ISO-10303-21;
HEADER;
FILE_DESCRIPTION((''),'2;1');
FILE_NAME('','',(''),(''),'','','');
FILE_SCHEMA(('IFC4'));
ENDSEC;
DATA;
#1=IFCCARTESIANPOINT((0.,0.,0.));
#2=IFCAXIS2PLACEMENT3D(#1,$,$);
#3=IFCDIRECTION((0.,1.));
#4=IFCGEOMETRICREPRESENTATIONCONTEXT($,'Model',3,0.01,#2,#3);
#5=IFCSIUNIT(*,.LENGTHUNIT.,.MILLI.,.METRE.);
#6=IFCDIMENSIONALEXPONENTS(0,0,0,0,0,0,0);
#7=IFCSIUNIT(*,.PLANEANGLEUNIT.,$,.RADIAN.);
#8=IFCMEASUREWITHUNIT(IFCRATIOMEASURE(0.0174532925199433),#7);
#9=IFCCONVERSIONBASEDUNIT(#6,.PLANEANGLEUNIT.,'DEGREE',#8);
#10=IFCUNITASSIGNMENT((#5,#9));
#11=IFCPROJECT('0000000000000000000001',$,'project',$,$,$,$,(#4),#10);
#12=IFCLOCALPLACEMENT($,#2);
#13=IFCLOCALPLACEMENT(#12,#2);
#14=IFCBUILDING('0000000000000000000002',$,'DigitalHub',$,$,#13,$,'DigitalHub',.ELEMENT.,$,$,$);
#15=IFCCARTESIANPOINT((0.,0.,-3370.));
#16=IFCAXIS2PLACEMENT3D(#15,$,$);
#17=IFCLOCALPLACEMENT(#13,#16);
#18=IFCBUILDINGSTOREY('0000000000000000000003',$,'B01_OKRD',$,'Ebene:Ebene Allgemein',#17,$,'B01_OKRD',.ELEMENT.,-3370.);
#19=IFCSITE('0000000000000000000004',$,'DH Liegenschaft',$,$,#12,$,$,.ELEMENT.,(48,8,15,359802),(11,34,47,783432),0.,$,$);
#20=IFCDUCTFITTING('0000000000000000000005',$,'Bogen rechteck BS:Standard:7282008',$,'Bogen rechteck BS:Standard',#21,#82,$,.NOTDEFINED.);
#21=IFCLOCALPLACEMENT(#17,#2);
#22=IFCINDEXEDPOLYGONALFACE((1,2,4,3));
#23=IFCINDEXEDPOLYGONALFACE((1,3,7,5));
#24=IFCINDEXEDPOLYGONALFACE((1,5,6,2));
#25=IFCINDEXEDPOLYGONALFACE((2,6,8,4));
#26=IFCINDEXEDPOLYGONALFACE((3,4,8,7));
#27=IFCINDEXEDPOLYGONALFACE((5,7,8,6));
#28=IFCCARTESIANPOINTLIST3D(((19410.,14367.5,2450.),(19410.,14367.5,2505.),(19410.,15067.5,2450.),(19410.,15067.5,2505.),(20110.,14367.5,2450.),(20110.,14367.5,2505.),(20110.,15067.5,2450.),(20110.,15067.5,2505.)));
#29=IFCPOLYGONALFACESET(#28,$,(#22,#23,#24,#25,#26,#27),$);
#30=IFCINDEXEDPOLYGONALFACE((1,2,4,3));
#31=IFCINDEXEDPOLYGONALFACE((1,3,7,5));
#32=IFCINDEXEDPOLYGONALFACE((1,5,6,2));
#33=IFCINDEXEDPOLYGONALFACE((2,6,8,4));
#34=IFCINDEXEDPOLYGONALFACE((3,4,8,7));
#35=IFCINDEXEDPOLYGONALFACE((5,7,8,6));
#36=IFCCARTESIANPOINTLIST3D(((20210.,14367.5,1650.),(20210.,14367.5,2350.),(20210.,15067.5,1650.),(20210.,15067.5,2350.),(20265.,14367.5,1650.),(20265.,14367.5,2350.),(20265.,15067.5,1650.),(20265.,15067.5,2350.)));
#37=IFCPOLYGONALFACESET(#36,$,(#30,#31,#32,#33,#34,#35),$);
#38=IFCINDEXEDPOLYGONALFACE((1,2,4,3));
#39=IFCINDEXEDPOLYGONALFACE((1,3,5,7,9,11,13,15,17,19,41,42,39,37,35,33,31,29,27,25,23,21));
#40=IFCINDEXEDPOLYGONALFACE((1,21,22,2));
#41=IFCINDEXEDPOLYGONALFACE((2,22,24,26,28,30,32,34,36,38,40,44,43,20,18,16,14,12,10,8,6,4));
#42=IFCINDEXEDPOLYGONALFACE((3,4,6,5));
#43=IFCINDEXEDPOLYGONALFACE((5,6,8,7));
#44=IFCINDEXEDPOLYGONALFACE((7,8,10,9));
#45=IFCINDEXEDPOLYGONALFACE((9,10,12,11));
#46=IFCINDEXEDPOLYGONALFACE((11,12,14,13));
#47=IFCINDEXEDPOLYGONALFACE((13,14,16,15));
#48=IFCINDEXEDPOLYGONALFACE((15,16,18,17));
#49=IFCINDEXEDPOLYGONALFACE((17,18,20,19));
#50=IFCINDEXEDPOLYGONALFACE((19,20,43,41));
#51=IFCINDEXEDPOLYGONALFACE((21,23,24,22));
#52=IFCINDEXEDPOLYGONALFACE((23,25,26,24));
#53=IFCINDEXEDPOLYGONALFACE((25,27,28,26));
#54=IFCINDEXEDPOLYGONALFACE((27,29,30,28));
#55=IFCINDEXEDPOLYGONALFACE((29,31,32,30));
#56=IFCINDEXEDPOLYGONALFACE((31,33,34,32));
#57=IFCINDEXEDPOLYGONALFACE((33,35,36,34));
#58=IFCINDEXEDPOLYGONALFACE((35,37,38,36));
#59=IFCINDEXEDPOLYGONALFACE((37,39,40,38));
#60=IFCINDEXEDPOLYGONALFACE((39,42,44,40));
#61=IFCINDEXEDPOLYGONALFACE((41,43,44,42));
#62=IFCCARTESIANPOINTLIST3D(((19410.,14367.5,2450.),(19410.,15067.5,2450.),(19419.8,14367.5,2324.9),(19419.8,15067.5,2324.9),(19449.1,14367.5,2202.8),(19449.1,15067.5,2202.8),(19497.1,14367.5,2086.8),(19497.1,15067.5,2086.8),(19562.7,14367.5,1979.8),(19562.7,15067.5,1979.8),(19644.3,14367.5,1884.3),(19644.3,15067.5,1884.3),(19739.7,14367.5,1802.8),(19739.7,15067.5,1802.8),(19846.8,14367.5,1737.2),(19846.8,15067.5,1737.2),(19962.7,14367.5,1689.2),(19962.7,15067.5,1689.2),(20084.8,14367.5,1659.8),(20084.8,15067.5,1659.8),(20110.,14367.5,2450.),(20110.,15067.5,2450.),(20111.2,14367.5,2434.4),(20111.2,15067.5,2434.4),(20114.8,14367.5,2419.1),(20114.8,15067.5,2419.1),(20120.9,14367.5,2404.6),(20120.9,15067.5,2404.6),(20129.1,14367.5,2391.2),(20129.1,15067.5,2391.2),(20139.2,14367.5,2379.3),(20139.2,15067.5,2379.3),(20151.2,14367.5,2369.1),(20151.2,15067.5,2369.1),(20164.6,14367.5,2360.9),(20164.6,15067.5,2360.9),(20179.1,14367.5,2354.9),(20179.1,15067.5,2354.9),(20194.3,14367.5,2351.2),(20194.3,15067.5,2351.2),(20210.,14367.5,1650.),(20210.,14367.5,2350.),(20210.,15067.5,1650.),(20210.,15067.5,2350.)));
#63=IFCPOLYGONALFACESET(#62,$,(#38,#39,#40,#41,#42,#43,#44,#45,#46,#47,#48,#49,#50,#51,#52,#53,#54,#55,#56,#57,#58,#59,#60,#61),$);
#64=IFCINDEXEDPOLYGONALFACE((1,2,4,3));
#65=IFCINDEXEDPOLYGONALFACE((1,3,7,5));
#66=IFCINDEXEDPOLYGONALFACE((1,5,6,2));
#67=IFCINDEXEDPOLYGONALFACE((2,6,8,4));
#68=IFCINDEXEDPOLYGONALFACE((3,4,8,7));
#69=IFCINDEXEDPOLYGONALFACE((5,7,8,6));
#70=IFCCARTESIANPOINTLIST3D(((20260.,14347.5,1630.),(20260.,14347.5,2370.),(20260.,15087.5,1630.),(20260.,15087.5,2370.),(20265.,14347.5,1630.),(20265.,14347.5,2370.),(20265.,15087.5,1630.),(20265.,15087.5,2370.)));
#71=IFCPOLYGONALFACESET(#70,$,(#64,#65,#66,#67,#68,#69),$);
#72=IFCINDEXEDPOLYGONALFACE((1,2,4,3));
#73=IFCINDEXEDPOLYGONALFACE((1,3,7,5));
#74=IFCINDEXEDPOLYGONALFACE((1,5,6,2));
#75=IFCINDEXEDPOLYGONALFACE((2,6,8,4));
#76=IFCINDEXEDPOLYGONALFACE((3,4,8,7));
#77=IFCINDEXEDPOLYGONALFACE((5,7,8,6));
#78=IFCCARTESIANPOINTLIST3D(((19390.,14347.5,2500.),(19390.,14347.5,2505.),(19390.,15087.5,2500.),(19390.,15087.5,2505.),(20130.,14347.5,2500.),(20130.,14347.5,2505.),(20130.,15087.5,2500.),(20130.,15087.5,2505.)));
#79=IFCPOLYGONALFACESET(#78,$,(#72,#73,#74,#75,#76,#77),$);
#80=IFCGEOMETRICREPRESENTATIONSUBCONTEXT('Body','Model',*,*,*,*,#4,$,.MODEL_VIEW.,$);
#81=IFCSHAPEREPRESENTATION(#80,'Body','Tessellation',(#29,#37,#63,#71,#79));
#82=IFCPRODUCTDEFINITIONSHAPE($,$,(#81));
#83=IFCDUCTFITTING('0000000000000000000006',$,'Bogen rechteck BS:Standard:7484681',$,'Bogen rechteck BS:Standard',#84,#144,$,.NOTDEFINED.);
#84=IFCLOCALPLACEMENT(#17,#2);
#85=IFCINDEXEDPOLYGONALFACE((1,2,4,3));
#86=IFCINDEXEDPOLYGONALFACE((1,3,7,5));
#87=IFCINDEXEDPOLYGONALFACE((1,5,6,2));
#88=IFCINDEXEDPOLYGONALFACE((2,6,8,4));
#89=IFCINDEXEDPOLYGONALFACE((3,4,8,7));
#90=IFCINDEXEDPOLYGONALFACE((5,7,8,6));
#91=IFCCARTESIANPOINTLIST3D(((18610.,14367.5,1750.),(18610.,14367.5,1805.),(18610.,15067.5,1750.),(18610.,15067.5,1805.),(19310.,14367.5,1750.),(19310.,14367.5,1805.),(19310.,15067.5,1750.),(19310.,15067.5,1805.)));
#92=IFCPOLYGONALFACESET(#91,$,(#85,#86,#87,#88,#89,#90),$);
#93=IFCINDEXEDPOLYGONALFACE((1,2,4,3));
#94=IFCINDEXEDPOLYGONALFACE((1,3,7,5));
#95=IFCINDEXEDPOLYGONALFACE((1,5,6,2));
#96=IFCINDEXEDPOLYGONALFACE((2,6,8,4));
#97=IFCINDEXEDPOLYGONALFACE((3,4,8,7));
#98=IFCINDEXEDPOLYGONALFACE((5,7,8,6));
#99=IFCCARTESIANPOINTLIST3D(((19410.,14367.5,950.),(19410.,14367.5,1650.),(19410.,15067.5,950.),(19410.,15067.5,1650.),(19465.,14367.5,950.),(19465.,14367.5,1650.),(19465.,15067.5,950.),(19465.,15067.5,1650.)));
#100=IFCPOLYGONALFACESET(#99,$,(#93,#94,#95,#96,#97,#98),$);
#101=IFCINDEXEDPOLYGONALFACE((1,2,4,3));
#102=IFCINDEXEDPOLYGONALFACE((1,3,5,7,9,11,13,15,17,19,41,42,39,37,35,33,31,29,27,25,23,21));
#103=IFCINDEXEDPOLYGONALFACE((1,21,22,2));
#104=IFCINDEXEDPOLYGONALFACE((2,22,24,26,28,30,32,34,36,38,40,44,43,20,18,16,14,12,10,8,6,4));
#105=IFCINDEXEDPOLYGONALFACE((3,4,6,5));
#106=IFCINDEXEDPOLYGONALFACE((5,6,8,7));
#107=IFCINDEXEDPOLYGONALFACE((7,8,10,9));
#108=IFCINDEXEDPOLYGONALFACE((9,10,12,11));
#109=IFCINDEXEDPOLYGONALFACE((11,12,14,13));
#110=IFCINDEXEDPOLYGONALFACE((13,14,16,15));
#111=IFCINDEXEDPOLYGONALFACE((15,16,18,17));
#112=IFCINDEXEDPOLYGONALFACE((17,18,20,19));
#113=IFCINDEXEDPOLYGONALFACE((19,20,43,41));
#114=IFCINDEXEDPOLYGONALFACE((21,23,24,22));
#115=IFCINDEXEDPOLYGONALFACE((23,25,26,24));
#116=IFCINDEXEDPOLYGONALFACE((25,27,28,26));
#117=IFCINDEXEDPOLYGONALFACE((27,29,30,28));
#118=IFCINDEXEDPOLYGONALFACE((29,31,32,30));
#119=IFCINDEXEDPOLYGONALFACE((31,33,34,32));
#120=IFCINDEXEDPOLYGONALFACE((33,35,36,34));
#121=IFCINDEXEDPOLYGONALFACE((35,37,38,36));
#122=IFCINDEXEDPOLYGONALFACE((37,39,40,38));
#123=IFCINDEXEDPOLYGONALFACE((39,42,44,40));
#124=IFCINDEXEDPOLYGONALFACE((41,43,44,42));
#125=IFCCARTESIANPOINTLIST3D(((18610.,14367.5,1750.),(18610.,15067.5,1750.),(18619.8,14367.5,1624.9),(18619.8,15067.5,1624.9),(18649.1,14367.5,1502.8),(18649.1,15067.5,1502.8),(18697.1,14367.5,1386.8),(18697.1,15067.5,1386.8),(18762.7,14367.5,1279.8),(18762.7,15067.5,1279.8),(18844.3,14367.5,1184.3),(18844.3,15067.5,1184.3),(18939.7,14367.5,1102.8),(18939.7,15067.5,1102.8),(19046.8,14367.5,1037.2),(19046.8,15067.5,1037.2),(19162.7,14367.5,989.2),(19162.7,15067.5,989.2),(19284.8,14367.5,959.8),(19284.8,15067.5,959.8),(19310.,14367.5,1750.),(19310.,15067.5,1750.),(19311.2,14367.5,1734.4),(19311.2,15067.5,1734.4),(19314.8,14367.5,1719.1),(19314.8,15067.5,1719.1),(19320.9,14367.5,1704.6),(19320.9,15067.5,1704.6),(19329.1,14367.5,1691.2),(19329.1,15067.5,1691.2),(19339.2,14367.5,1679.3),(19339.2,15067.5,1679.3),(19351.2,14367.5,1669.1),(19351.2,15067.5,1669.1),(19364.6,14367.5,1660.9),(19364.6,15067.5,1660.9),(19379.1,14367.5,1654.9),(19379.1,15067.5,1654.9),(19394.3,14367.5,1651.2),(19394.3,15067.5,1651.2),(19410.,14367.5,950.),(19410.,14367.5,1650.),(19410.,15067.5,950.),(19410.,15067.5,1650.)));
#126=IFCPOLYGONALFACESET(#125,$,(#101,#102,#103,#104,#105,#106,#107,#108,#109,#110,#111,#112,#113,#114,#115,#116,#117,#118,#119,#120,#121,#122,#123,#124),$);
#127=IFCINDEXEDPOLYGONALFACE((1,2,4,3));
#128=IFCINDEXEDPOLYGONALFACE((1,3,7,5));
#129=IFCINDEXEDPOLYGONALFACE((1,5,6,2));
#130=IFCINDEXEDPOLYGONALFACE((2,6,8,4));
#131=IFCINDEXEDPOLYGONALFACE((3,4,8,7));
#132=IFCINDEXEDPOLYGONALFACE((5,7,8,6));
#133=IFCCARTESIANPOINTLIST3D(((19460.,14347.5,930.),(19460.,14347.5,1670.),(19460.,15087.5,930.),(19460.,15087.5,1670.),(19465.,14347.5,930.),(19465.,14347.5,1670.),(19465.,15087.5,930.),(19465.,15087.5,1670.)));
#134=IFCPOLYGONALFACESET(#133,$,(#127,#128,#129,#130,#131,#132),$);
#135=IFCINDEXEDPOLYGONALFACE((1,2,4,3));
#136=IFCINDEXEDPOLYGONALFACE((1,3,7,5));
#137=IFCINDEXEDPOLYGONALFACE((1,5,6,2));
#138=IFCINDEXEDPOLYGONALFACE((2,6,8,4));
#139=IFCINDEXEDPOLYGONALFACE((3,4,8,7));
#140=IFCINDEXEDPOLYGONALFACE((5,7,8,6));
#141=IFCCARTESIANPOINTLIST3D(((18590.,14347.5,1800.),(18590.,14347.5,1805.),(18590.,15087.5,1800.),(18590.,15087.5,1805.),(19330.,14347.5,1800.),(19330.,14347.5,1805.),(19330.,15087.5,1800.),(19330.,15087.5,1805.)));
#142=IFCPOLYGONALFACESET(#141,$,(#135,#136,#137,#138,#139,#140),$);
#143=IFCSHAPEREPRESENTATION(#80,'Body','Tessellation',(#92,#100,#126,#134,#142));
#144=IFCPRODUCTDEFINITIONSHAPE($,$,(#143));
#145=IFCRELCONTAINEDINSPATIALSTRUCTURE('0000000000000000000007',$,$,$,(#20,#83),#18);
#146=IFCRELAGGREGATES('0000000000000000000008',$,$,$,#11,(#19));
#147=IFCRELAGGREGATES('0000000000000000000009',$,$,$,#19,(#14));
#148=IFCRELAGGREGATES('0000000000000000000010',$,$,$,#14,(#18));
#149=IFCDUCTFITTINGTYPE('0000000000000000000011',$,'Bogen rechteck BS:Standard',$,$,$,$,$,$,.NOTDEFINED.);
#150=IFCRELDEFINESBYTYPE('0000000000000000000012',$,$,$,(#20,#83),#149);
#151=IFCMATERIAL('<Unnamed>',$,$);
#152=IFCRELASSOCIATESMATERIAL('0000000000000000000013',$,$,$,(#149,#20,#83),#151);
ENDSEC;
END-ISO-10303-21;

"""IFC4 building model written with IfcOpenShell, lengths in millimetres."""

from ifc_helpers import new_model, entity, si_unit, converted_unit, direction, frame, origin, place, context, subcontext, project, spatial, indexed_curve, outline, extrude, source, transform, mapped, material, type_object, type_shapes, element, save


model = new_model("IFC4")

# Units and contexts
model_context = context("Model", 3, precision=0.01, world=origin(), true_north=direction((0.0, 1.0)))
body_context = subcontext(model_context, "Body", "Model", "MODEL_VIEW")
ifc_project = project(units=[si_unit("LENGTHUNIT", "METRE", prefix="MILLI"), converted_unit("PLANEANGLEUNIT", "DEGREE", entity("IfcRatioMeasure", 0.0174532925199433), si_unit("PLANEANGLEUNIT", "RADIAN"), dimensions=[0, 0, 0, 0, 0, 0, 0])], contexts=[model_context])

# Site, building, storey
site_placement = place(None, origin())
site = spatial("IfcSite", under=ifc_project, at=site_placement, Name="DH Liegenschaft", CompositionType="ELEMENT", RefLatitude=(48, 8, 15, 359802), RefLongitude=(11, 34, 47, 783432), RefElevation=0.0)
building_placement = place(site_placement, origin())
building = spatial("IfcBuilding", under=site, at=building_placement, Name="DigitalHub", LongName="DigitalHub", CompositionType="ELEMENT")
storey_placement = place(building_placement, frame((0.0, 0.0, -3370.0)))
storey = spatial("IfcBuildingStorey", under=building, at=storey_placement, Name="B01_OKRD", ObjectType="Ebene:Ebene Allgemein", LongName="B01_OKRD", CompositionType="ELEMENT", Elevation=-3370.0)

# Shared definitions
ifc_material_1 = material(Name="<Unnamed>")

# Duct fittings
duct_fitting_type_1 = type_object("IfcDuctFittingType", Name="Bogen rechteck BS:Standard", PredefinedType="NOTDEFINED", material=ifc_material_1)
shared_shape_1 = source(origin(), body_context, "Body", "SweptSolid", [
    extrude(outline(indexed_curve([(-27.5, -350.0), (27.5, -350.0), (27.5, 350.0), (-27.5, 350.0), (-27.5, -350.0)], self_intersect=False)), frame((0.0, 477.5, -350.0), z_axis=(0.0, 0.0, 1.0), x_axis=(0.0, 1.0, 0.0)), (0.0, 0.0, 1.0), 700.0),
    extrude(outline(indexed_curve([(-350.0, -27.5), (350.0, -27.5), (350.0, 27.5), (-350.0, 27.5), (-350.0, -27.5)], self_intersect=False)), frame((-477.5, 0.0, -350.0), z_axis=(0.0, 0.0, 1.0), x_axis=(0.0, -1.0, 0.0)), (0.0, 0.0, 1.0), 700.0),
    extrude(outline(indexed_curve([(-575.0, -225.0), (125.0, -225.0), (126.2, -209.4), (129.9, -194.1), (135.9, -179.6), (144.1, -166.2), (154.3, -154.3), (166.2, -144.1), (179.6, -135.9), (194.1, -129.9), (209.4, -126.2), (225.0, -125.0), (225.0, 575.0), (99.9, 565.2), (-22.2, 535.8), (-138.2, 487.8), (-245.2, 422.2), (-340.7, 340.7), (-422.2, 245.2), (-487.8, 138.2), (-535.8, 22.2), (-565.2, -99.9), (-575.0, -225.0)], self_intersect=False)), frame((-225.0, 225.0, -350.0), z_axis=(0.0, 0.0, 1.0), x_axis=(-1.0, 0.0, 0.0)), (0.0, 0.0, 1.0), 700.0),
    extrude(outline(indexed_curve([(-2.5, -370.0), (2.5, -370.0), (2.5, 370.0), (-2.5, 370.0), (-2.5, -370.0)], self_intersect=False)), frame((-502.5, 0.0, -370.0)), (0.0, 0.0, 1.0), 740.0),
    extrude(outline(indexed_curve([(-2.5, -370.0), (2.5, -370.0), (2.5, 370.0), (-2.5, 370.0), (-2.5, -370.0)], self_intersect=False)), frame((0.0, 502.5, -370.0), z_axis=(0.0, 0.0, 1.0), x_axis=(0.0, 1.0, 0.0)), (0.0, 0.0, 1.0), 740.0),
])
type_shapes(duct_fitting_type_1, [shared_shape_1])
for number, where, z_axis, x_axis, name in (
    (1, (19760.0, 14717.5, 2000.0), (0.0, 1.0, 0.0), (-1.0, 0.0, 0.0), "Bogen rechteck BS:Standard:7282008"),
    (2, (18960.0, 14717.5, 1300.0), (0.0, 1.0, 0.0), (-1.0, 0.0, 0.0), "Bogen rechteck BS:Standard:7484681"),
):
    element("IfcDuctFitting", number, at=place(storey_placement, frame(where, z_axis=z_axis, x_axis=x_axis)), inside=storey, type_object=duct_fitting_type_1, material=ifc_material_1, Name=name, ObjectType="Bogen rechteck BS:Standard", PredefinedType="NOTDEFINED", context=body_context, shape_type="MappedRepresentation", body=[
        mapped(shared_shape_1, transform((0.0, 0.0, 0.0), scale=1.0)),
    ])

save(model, "model.ifc")
